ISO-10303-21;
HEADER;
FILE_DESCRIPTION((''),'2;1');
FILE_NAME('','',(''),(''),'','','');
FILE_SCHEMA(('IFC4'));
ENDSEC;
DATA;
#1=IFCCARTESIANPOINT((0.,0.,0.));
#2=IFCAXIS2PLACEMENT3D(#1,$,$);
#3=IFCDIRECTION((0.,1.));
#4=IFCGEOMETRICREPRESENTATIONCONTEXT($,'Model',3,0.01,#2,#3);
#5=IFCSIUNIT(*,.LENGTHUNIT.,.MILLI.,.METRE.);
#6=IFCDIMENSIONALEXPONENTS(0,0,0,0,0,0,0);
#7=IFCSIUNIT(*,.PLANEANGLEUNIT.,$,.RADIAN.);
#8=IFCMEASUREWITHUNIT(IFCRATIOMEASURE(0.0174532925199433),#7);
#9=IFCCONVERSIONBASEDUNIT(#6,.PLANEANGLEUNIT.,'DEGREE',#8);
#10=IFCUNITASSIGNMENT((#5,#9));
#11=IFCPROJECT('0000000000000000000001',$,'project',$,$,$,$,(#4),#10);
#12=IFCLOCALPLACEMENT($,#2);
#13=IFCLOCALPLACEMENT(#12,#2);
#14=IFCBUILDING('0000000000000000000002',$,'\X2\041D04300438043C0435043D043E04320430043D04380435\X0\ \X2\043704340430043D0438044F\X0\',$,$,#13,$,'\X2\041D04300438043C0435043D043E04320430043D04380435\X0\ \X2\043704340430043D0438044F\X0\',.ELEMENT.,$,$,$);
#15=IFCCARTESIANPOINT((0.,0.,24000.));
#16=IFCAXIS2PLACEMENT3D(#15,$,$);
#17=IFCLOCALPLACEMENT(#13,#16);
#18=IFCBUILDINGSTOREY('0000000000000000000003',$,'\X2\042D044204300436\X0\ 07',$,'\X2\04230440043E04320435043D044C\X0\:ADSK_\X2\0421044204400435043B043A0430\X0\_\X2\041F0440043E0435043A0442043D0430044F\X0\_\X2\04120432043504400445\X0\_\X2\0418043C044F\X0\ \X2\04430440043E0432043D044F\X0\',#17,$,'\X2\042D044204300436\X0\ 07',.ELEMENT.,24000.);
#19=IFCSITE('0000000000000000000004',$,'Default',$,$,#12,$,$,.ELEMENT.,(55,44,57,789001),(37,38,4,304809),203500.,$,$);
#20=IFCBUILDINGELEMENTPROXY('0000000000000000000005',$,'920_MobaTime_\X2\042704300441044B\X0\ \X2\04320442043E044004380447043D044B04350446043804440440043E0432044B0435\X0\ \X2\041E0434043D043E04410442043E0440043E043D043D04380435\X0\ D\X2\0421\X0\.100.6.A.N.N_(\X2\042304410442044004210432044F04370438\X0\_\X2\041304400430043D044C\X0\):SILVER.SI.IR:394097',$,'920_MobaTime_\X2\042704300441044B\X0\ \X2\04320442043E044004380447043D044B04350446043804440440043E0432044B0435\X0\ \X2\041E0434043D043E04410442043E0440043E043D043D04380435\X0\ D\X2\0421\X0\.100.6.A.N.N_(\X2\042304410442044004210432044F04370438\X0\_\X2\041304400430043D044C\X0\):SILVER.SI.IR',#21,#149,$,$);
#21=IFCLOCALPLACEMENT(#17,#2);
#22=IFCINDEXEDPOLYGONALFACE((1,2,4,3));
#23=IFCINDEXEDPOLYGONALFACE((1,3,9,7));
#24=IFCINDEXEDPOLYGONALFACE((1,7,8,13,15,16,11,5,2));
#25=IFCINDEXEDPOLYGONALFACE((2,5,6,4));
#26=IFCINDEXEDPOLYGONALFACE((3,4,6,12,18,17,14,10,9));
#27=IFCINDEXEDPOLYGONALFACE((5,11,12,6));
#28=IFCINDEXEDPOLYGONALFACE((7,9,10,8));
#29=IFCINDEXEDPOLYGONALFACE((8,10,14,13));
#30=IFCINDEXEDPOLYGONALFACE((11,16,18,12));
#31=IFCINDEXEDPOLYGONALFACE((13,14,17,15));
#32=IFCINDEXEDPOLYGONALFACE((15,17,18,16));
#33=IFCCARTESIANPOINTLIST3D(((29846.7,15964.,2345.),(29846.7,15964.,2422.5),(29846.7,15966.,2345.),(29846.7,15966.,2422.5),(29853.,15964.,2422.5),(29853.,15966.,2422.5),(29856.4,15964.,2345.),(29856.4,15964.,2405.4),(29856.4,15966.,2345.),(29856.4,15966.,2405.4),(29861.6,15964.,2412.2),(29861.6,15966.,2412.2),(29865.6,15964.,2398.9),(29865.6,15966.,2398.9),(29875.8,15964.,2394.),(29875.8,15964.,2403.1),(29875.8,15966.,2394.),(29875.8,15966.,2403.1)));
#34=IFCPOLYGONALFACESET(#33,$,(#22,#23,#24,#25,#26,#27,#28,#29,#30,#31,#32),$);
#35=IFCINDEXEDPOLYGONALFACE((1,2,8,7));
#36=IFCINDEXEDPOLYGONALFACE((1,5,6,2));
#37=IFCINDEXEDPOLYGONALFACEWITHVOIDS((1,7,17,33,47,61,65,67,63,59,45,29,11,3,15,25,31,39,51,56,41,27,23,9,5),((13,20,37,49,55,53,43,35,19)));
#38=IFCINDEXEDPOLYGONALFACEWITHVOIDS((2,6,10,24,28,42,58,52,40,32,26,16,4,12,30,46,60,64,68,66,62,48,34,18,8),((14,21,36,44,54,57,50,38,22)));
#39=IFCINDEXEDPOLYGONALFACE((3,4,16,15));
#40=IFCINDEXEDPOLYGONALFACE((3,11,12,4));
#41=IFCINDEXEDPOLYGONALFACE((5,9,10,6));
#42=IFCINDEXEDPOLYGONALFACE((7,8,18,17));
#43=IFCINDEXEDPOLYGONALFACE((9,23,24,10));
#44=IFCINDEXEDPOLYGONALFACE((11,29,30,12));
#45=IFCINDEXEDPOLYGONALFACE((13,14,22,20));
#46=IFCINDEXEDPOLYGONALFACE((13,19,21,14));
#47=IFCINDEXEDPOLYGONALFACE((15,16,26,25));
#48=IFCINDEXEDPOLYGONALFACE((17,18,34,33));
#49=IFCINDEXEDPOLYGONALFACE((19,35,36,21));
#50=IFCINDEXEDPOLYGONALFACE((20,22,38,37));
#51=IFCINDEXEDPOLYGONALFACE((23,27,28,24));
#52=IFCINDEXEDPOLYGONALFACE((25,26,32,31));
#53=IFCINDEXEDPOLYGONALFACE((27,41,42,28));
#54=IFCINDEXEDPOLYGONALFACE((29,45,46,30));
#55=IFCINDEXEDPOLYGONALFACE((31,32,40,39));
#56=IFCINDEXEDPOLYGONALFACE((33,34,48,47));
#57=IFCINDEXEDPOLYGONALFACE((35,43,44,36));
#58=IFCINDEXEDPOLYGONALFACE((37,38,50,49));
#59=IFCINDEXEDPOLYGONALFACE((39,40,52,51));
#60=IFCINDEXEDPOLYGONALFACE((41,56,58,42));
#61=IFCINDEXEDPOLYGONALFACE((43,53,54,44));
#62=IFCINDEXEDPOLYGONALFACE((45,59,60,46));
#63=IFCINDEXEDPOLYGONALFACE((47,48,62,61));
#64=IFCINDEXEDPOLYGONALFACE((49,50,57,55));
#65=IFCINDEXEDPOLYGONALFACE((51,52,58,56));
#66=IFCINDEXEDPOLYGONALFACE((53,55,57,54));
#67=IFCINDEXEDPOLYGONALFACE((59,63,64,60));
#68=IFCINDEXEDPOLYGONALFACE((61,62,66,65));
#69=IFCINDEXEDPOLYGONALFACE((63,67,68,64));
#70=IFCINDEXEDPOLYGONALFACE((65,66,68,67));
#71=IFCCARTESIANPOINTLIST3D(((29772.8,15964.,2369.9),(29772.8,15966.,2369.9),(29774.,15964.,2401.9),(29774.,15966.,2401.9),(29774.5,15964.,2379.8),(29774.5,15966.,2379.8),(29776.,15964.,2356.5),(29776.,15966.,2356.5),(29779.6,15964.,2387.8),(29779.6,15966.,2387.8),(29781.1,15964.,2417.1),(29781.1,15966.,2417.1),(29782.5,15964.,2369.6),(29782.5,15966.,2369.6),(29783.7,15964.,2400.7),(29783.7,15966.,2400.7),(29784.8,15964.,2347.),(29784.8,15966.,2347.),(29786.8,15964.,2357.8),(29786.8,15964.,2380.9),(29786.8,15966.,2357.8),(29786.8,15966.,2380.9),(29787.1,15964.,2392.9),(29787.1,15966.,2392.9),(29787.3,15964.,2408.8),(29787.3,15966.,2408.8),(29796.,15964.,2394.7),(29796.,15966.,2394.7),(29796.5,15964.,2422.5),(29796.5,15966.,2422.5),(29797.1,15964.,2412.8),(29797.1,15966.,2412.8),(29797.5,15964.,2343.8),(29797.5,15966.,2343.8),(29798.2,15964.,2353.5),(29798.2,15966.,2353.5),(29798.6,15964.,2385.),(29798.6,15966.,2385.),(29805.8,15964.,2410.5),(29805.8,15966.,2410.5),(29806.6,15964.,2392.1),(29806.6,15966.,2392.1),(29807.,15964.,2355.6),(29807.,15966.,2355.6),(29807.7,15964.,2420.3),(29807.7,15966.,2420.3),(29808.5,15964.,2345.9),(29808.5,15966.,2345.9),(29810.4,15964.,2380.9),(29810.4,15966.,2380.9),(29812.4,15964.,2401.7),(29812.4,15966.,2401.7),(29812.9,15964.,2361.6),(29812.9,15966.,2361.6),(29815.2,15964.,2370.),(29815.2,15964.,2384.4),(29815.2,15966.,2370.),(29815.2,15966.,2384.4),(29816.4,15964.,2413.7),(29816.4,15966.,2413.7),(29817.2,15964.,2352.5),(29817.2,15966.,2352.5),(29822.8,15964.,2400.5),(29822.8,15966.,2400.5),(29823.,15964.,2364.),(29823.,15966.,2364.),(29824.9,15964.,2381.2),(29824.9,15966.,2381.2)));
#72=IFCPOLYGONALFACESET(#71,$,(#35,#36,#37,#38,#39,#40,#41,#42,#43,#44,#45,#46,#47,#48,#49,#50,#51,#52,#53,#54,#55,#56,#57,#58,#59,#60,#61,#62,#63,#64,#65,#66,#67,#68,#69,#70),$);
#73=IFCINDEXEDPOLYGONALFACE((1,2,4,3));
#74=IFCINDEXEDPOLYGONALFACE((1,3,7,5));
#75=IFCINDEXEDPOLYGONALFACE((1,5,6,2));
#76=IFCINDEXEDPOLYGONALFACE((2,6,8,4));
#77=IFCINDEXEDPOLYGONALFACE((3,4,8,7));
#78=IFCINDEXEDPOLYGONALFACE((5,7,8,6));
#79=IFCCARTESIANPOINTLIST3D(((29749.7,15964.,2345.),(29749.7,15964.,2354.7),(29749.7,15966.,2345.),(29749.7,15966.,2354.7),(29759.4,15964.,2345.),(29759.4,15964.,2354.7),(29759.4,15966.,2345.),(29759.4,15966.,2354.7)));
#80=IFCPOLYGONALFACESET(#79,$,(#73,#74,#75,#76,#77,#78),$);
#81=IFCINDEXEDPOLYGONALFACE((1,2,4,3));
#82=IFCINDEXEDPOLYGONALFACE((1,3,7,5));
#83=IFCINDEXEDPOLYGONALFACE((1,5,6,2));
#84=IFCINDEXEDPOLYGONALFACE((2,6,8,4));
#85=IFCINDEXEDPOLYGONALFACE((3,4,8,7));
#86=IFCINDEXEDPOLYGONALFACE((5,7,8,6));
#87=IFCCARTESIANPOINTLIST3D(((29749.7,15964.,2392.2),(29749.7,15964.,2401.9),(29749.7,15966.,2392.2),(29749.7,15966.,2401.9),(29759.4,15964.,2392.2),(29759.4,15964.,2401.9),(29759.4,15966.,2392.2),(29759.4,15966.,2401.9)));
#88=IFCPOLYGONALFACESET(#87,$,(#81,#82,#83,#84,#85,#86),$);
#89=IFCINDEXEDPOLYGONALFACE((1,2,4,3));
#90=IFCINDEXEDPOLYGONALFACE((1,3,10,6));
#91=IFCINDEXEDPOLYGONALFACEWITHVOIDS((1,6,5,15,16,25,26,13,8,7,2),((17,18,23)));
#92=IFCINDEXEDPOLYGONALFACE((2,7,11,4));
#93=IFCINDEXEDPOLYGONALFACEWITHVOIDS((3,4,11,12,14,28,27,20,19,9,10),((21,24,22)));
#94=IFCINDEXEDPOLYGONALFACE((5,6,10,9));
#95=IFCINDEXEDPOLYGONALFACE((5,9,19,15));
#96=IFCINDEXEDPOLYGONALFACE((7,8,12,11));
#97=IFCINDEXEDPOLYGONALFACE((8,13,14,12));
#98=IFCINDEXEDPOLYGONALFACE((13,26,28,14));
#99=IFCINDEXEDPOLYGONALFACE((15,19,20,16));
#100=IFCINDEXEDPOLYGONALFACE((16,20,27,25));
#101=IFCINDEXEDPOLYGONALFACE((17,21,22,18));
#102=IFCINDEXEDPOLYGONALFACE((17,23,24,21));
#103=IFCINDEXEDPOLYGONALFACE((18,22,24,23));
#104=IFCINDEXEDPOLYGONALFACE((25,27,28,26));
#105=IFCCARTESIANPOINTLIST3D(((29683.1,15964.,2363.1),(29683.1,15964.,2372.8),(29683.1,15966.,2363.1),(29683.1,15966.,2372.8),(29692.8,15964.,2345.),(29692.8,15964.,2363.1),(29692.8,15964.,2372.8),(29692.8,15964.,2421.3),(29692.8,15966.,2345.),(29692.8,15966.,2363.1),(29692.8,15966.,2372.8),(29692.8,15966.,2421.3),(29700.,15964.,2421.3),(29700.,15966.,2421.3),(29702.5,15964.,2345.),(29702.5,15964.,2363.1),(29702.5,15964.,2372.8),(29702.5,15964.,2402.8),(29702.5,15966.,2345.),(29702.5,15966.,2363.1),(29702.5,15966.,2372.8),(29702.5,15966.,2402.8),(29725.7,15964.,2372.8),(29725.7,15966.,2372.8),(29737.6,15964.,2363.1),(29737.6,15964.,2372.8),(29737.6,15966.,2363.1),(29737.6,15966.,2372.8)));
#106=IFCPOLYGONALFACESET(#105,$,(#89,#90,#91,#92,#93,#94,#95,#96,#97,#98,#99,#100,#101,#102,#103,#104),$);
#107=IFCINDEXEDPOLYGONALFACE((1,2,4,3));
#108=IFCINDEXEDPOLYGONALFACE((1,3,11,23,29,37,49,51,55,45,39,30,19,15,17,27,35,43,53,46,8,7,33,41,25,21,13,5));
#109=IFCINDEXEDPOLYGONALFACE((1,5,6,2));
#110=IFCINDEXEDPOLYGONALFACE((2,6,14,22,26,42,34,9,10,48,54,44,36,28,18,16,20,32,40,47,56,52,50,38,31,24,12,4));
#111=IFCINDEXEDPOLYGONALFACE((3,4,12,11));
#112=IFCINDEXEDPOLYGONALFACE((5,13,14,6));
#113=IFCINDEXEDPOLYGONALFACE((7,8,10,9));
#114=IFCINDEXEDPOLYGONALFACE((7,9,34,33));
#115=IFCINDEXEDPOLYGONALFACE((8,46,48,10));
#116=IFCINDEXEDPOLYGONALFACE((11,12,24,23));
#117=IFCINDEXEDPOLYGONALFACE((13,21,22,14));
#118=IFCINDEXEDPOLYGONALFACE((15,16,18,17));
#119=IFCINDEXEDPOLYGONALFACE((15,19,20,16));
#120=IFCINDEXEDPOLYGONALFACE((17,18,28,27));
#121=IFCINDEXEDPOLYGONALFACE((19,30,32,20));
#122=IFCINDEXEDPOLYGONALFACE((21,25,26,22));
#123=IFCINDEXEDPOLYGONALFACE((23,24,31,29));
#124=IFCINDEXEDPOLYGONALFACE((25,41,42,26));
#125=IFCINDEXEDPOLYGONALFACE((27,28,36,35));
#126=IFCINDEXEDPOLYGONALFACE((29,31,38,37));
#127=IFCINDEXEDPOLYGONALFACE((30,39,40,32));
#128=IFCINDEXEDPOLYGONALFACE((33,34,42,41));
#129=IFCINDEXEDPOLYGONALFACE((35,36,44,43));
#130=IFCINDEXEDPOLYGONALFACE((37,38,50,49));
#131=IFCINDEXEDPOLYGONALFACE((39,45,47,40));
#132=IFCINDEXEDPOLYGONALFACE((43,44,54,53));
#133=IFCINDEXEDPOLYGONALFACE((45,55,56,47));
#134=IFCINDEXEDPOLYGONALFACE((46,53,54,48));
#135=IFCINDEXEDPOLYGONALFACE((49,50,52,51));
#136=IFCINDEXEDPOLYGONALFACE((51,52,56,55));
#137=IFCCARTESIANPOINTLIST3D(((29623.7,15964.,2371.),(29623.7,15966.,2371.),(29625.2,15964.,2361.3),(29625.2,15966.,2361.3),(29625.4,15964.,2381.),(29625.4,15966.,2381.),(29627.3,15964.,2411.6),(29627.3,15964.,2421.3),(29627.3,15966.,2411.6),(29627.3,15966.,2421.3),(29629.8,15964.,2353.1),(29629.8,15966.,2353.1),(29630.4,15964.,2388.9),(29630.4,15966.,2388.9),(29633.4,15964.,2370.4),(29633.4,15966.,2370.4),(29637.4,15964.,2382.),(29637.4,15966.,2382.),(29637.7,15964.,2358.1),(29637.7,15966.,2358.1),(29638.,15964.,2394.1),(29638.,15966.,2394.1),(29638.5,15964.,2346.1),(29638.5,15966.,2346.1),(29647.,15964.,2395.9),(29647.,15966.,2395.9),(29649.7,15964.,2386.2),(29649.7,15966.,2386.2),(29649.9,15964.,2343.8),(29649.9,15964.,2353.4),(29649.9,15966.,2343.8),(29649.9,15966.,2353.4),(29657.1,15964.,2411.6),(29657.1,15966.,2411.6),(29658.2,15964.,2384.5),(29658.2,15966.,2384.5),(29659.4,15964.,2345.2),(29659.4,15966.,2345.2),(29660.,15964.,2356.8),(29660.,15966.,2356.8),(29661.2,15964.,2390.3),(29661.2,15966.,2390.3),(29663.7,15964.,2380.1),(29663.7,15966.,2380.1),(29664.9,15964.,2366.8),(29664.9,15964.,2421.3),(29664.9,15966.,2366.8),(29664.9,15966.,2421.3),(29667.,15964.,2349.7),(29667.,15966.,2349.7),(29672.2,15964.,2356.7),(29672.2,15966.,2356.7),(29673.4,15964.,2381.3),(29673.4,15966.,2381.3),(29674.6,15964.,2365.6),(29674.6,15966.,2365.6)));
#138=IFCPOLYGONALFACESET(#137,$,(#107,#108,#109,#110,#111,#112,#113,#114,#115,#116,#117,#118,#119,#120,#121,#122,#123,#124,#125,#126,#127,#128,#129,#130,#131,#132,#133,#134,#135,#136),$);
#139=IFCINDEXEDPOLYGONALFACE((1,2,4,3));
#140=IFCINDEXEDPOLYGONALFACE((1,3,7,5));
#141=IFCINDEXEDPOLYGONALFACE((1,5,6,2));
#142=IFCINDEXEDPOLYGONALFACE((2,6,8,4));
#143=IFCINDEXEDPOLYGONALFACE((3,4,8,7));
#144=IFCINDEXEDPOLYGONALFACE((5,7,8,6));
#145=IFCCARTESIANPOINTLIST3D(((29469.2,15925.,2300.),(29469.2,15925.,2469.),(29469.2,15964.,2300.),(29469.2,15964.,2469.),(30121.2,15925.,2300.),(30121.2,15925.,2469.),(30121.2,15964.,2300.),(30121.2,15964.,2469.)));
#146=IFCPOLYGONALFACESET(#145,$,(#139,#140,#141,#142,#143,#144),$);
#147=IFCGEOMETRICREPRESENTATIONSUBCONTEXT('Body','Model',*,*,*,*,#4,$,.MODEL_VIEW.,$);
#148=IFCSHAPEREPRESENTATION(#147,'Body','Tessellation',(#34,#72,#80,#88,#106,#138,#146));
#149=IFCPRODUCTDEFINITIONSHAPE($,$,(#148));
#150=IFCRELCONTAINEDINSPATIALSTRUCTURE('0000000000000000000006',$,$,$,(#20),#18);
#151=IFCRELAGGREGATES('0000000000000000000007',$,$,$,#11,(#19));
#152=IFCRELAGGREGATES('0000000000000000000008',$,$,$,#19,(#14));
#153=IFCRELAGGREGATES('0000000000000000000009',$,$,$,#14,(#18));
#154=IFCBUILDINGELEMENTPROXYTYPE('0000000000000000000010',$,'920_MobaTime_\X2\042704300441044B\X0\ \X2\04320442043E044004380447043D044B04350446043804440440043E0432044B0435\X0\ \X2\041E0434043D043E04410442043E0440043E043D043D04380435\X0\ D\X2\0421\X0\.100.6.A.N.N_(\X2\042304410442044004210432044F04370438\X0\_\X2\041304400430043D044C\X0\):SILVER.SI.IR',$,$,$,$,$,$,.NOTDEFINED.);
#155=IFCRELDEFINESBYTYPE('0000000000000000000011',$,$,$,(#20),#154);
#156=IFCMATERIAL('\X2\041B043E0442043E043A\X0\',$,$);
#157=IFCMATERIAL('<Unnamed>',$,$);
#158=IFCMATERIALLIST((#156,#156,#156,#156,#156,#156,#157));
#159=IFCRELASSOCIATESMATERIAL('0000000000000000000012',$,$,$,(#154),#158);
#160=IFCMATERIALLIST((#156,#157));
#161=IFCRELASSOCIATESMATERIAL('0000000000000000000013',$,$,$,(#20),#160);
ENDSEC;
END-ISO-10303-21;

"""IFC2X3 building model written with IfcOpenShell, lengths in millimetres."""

from ifc_helpers import new_model, entity, si_unit, converted_unit, direction, frame, origin, origin_2d_with_axis, place, context, subcontext, project, spatial, polyline, rectangle, outline, extrude, source, transform, mapped, material, material_list, type_object, type_shapes, element, save


model = new_model("IFC2X3")

# Units and contexts
model_context = context("Model", 3, precision=0.01, world=origin(), true_north=direction((0.0, 1.0)))
body_context = subcontext(model_context, "Body", "Model", "MODEL_VIEW")
ifc_project = project(units=[si_unit("LENGTHUNIT", "METRE", prefix="MILLI"), converted_unit("PLANEANGLEUNIT", "DEGREE", entity("IfcRatioMeasure", 0.0174532925199433), si_unit("PLANEANGLEUNIT", "RADIAN"), dimensions=[0, 0, 0, 0, 0, 0, 0])], contexts=[model_context])

# Site, building, storey
site_placement = place(None, origin())
site = spatial("IfcSite", under=ifc_project, at=site_placement, Name="Default", CompositionType="ELEMENT", RefLatitude=(55, 44, 57, 789001), RefLongitude=(37, 38, 4, 304809), RefElevation=203500.0)
building_placement = place(site_placement, origin())
building = spatial("IfcBuilding", under=site, at=building_placement, Name="Наименование здания", LongName="Наименование здания", CompositionType="ELEMENT")
storey_placement = place(building_placement, frame((0.0, 0.0, 24000.0)))
storey = spatial("IfcBuildingStorey", under=building, at=storey_placement, Name="Этаж 07", ObjectType="Уровень:ADSK_Стрелка_Проектная_Вверх_Имя уровня", LongName="Этаж 07", CompositionType="ELEMENT", Elevation=24000.0)

# Building element proxy
ifc_material_1 = material(Name="Лоток")
ifc_material_2 = material(Name="<Unnamed>")
ifc_material_list_1 = material_list([ifc_material_1, ifc_material_2])
ifc_material_list_2 = material_list([ifc_material_1, ifc_material_1, ifc_material_1, ifc_material_1, ifc_material_1, ifc_material_1, ifc_material_2])
building_element_proxy_type = type_object("IfcBuildingElementProxyType", Name="920_MobaTime_Часы вторичныецифровые Односторонние DС.100.6.A.N.N_(УстрСвязи_Грань):SILVER.SI.IR", PredefinedType="NOTDEFINED", material=ifc_material_list_2)
shared_shape = source(origin(), body_context, "Body", "SweptSolid", [
    extrude(outline(polyline([(-49.3, -13.1), (28.2, -13.1), (28.2, -6.8), (17.9, 1.8), (8.8, 16.0), (-0.3, 16.0), (4.6, 5.8), (11.1, -3.4), (-49.3, -3.4), (-49.3, -13.1)])), frame((-64.6, 9.8, 39.0), z_axis=(0.0, 0.0, 1.0), x_axis=(0.0, 1.0, 0.0)), (0.0, 0.0, 1.0), 2.0),
    extrude(outline(polyline([(2.2, -27.6), (19.0, -27.6), (30.5, -16.1), (33.3, -4.9), (31.0, 5.8), (21.8, 17.2), (5.2, 27.3), (-11.1, 33.0), (-24.0, 32.7), (-33.6, 27.6), (-40.3, 18.6), (-42.8, 5.7), (-38.0, -6.3), (-27.2, -14.9), (-17.5, -17.7), (-8.2, -16.4), (-0.3, -11.9), (5.1, -4.5), (7.3, 6.2), (4.0, 17.2), (18.4, 7.3), (23.6, -2.4), (22.0, -11.4), (14.2, -18.4), (5.3, -18.3), (2.2, -27.6)]), holes=[polyline([(-9.0, 23.3), (-1.3, 14.3), (-2.5, 2.0), (-11.4, -7.0), (-23.4, -6.0), (-32.2, 2.9), (-31.2, 15.1), (-25.6, 22.1), (-17.5, 24.9), (-9.0, 23.3)])]), frame((-2.7, 3.6, 39.0), z_axis=(0.0, 0.0, 1.0), x_axis=(-0.427649, 0.903945, 0.0)), (0.0, 0.0, 1.0), 2.0),
    extrude(rectangle(XDim=9.7, YDim=9.7, at=origin_2d_with_axis()), frame((40.6, -34.7, 39.0)), (0.0, 0.0, 1.0), 2.0),
    extrude(rectangle(XDim=9.7, YDim=9.7, at=origin_2d_with_axis()), frame((40.6, 12.6, 39.0)), (0.0, 0.0, 1.0), 2.0),
    extrude(outline(polyline([(-0.9, -28.1), (8.8, -28.1), (8.8, -9.9), (18.5, -9.9), (18.5, -0.2), (8.8, -0.2), (8.8, 48.3), (1.5, 48.3), (-36.0, -0.2), (-36.0, -9.9), (-0.9, -9.9), (-0.9, -28.1)]), holes=[polyline([(-0.9, -0.2), (-24.1, -0.2), (-0.9, 29.7), (-0.9, -0.2)])]), frame((93.6, -11.4, 39.0)), (0.0, 0.0, 1.0), 2.0),
    extrude(outline(polyline([(3.3, -28.3), (12.5, -28.3), (20.5, -25.0), (26.8, -18.9), (30.7, -10.0), (31.4, 1.6), (26.9, 11.8), (20.1, 18.4), (11.1, 22.3), (1.0, 23.3), (-7.9, 20.4), (-14.9, 14.5), (-18.9, 6.2), (-17.1, -9.0), (-36.7, 0.5), (-29.1, 29.2), (-38.5, 31.7), (-48.1, -4.6), (-11.6, -23.1), (-8.0, -14.0), (-10.8, -7.6), (-10.2, 1.1), (-3.0, 11.8), (9.2, 12.8), (20.0, 5.5), (21.4, -7.5), (15.5, -16.4), (4.6, -18.6), (3.3, -28.3)])), frame((147.1, -8.5, 39.0), z_axis=(0.0, 0.0, 1.0), x_axis=(0.256974, -0.966418, 0.0)), (0.0, 0.0, 1.0), 2.0),
    extrude(rectangle(XDim=652.0, YDim=169.0, at=origin_2d_with_axis()), frame((0.0, 0.0, 0.0), z_axis=(0.0, 0.0, 1.0), x_axis=(-1.0, 0.0, 0.0)), (0.0, 0.0, 1.0), 39.0),
])
type_shapes(building_element_proxy_type, [shared_shape])
for number, where, z_axis, x_axis, name in (
    (1, (29795.2, 15925.0, 2384.5), (0.0, 1.0, 0.0), (-1.0, 0.0, 0.0), "920_MobaTime_Часы вторичныецифровые Односторонние DС.100.6.A.N.N_(УстрСвязи_Грань):SILVER.SI.IR:394097"),
):
    element("IfcBuildingElementProxy", number, at=place(storey_placement, frame(where, z_axis=z_axis, x_axis=x_axis)), inside=storey, type_object=building_element_proxy_type, material=ifc_material_list_1, Name=name, ObjectType="920_MobaTime_Часы вторичныецифровые Односторонние DС.100.6.A.N.N_(УстрСвязи_Грань):SILVER.SI.IR", context=body_context, shape_type="MappedRepresentation", body=[
        mapped(shared_shape, transform((0.0, 0.0, 0.0), scale=1.0)),
    ])

save(model, "model.ifc")
